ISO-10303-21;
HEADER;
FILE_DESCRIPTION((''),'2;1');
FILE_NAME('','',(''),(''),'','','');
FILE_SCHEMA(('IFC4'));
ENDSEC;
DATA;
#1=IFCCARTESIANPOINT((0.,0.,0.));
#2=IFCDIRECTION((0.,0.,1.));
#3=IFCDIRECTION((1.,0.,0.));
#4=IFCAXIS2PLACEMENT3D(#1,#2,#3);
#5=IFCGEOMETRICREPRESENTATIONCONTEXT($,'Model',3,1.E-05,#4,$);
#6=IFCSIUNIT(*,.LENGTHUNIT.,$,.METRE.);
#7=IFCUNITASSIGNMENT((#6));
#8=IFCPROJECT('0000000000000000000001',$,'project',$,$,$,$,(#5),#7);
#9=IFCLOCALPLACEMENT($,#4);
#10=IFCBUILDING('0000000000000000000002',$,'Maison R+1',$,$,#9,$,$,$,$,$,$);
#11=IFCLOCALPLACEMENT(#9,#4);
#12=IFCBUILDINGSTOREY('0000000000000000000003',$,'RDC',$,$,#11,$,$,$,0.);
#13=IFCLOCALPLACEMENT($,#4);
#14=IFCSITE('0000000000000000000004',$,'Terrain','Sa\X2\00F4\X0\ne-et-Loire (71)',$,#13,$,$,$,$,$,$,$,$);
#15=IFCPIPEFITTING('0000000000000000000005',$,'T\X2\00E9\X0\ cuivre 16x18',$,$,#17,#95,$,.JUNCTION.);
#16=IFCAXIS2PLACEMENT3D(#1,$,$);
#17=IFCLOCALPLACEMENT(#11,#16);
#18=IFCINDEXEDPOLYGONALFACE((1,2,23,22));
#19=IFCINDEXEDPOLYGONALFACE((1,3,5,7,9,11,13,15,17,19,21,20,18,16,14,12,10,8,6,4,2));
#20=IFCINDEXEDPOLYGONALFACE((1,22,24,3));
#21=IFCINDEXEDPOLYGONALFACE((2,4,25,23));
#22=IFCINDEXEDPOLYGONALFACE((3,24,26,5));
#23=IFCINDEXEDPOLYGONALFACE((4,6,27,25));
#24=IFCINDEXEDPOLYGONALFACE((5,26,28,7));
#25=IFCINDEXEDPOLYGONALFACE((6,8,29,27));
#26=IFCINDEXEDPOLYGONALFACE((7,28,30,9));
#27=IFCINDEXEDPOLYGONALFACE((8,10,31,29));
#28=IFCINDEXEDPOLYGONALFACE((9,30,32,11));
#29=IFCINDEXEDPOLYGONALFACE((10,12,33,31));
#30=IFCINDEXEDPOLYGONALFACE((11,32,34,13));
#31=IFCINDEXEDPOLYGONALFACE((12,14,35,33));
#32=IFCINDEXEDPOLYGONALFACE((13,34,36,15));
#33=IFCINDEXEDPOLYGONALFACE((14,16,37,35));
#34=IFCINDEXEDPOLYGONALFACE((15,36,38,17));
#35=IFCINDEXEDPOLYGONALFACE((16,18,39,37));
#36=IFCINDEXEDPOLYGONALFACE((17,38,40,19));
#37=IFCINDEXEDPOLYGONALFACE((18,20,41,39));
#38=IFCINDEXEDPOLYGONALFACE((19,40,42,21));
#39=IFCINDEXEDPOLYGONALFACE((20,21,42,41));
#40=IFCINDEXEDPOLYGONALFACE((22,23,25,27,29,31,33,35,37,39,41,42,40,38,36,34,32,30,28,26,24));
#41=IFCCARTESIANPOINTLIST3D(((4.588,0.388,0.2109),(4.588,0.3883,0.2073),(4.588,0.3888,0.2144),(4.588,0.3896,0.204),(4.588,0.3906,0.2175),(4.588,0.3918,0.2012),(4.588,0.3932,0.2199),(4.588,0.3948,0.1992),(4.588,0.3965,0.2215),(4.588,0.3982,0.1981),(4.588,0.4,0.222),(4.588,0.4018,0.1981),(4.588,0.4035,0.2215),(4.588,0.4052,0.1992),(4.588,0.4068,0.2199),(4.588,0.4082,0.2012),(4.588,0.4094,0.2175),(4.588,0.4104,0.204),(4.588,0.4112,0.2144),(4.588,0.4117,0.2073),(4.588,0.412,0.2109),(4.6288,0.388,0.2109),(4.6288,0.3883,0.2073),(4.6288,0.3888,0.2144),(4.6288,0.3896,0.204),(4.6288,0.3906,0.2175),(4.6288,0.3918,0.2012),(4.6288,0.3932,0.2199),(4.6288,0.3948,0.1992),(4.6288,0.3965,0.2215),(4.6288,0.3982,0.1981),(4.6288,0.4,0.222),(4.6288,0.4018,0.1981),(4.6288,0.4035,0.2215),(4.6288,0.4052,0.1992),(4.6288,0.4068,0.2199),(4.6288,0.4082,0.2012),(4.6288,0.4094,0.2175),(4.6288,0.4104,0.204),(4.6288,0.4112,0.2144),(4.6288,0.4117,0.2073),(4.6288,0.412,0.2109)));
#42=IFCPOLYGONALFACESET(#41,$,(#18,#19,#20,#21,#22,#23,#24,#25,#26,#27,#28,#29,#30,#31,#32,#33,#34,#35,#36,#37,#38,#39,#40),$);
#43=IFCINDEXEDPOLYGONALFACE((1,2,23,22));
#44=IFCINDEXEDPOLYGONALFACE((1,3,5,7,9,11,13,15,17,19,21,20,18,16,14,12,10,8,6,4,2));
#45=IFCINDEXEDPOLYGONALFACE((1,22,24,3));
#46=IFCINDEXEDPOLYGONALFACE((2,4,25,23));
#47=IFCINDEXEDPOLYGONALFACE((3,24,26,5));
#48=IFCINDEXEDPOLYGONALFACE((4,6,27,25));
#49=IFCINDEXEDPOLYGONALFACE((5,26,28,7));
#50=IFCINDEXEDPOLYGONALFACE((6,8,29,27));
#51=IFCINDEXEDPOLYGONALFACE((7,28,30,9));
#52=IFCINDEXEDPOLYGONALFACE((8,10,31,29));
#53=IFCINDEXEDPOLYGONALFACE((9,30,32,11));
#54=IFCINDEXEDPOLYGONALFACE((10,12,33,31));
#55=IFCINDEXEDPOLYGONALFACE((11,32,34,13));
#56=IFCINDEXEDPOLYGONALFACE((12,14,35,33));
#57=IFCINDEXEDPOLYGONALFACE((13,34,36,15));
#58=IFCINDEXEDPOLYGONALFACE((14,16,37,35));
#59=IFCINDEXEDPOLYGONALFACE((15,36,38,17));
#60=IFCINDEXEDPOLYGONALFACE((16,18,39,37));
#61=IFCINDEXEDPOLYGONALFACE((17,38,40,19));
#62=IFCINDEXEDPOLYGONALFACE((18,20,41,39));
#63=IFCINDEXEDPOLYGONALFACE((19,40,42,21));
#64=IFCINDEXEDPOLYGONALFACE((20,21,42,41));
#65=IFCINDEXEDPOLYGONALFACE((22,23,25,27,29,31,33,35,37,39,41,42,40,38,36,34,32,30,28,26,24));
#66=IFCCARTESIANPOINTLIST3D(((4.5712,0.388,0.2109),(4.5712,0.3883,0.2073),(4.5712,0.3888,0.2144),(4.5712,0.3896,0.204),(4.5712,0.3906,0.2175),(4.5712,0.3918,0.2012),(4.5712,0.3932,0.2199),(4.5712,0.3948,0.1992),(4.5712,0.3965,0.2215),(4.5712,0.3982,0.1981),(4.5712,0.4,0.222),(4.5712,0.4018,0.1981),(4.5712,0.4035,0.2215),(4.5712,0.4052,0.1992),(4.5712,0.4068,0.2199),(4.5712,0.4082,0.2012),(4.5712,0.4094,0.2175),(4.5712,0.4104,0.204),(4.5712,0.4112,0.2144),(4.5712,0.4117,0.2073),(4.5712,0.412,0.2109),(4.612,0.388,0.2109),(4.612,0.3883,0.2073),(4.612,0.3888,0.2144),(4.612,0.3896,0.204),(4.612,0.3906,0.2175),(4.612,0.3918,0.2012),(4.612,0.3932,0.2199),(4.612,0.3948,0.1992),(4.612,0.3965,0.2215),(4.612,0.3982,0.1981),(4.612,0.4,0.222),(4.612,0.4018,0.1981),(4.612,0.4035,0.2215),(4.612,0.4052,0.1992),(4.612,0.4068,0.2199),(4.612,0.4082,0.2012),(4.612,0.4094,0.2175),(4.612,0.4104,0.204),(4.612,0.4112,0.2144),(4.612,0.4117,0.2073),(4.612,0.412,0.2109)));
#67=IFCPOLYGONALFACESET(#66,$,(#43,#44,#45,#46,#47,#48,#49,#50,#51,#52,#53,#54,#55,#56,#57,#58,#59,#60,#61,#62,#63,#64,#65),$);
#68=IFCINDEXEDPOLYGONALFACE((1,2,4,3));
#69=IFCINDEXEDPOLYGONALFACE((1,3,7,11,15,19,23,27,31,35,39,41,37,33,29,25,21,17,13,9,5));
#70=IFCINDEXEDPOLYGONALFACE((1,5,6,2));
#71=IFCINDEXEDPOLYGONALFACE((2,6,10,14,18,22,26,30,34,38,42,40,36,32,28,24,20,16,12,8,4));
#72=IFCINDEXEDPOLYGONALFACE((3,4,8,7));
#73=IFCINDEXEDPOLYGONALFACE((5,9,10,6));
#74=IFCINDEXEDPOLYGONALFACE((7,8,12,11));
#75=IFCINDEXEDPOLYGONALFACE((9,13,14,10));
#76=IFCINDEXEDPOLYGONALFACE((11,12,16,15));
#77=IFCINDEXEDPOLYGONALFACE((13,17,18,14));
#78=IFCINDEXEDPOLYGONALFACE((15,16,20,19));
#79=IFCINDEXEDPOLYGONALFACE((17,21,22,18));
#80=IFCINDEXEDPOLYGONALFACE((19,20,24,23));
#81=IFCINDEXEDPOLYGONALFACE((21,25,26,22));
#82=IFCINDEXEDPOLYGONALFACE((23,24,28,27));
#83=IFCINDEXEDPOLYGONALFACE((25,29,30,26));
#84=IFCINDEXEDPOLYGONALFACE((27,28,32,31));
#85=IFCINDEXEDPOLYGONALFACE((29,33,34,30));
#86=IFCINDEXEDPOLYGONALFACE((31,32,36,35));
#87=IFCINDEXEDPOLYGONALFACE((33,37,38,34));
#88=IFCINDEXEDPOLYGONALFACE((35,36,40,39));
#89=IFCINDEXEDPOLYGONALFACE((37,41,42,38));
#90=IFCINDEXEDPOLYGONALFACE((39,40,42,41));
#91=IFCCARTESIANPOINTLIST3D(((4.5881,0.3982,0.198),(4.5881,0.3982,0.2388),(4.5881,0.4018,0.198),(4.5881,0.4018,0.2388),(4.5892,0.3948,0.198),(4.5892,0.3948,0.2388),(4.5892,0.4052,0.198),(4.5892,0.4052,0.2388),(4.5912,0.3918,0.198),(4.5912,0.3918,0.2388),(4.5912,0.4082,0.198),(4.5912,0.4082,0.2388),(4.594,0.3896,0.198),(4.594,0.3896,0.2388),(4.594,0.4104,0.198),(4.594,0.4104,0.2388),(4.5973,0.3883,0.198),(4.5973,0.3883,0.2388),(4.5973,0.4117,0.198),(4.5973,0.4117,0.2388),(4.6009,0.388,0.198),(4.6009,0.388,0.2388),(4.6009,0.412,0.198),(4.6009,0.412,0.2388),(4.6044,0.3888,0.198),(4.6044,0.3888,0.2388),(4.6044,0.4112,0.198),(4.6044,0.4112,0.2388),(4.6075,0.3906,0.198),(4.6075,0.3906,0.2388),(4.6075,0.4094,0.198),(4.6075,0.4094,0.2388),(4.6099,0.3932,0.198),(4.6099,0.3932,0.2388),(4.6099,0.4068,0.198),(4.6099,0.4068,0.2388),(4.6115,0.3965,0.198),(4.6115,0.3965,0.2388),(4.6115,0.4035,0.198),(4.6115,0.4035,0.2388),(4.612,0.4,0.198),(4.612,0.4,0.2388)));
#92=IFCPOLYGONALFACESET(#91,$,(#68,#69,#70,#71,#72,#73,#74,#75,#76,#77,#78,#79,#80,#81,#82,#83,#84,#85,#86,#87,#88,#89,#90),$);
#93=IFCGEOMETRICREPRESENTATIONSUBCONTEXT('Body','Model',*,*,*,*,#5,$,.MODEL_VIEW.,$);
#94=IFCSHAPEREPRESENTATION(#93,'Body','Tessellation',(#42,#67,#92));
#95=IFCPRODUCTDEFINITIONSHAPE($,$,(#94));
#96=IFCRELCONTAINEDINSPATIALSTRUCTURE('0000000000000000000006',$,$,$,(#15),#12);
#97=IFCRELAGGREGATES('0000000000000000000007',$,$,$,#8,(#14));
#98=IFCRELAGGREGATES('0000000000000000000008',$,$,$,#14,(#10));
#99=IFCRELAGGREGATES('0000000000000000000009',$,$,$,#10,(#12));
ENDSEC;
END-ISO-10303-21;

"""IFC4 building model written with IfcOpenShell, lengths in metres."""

from ifc_helpers import new_model, si_unit, frame, origin_with_axes, place, context, subcontext, project, spatial, circle, extrude, element, save


model = new_model("IFC4")

# Units and contexts
model_context = context("Model", 3, precision=1e-05, world=origin_with_axes())
body_context = subcontext(model_context, "Body", "Model", "MODEL_VIEW")
ifc_project = project(units=[si_unit("LENGTHUNIT", "METRE")], contexts=[model_context])

# Site, building, storey
site_placement = place(None, origin_with_axes())
site = spatial("IfcSite", under=ifc_project, at=site_placement, Name="Terrain", Description="Saône-et-Loire (71)")
building_placement = place(None, origin_with_axes())
building = spatial("IfcBuilding", under=site, at=building_placement, Name="Maison R+1")
storey_placement = place(building_placement, origin_with_axes())
storey = spatial("IfcBuildingStorey", under=building, at=storey_placement, Name="RDC", Elevation=0.0)

# Pipe fitting
for number, where, z_axis, x_axis, name in (
    (1, (4.6, 0.4, 0.21), (0.0, 0.0, 1.0), (1.0, 0.0, 0.0), "Té cuivre 16x18"),
):
    element("IfcPipeFitting", number, at=place(storey_placement, frame(where, z_axis=z_axis, x_axis=x_axis)), inside=storey, Name=name, PredefinedType="JUNCTION", context=body_context, shape_type="SweptSolid", body=[
        extrude(circle(Radius=0.012), frame((-0.012, 0.0, 0.0), z_axis=(1.0, 0.0, 0.0), x_axis=(0.0, 0.0, 1.0)), (0.0, 0.0, 1.0), 0.0408),
        extrude(circle(Radius=0.012), frame((0.012, 0.0, 0.0), z_axis=(-1.0, 0.0, 0.0), x_axis=(0.0, 0.0, 1.0)), (0.0, 0.0, 1.0), 0.0408),
        extrude(circle(Radius=0.012), frame((0.0, 0.0, -0.012), z_axis=(0.0, 0.0, 1.0), x_axis=(1.0, 0.0, 0.0)), (0.0, 0.0, 1.0), 0.0408),
    ])

save(model, "model.ifc")
